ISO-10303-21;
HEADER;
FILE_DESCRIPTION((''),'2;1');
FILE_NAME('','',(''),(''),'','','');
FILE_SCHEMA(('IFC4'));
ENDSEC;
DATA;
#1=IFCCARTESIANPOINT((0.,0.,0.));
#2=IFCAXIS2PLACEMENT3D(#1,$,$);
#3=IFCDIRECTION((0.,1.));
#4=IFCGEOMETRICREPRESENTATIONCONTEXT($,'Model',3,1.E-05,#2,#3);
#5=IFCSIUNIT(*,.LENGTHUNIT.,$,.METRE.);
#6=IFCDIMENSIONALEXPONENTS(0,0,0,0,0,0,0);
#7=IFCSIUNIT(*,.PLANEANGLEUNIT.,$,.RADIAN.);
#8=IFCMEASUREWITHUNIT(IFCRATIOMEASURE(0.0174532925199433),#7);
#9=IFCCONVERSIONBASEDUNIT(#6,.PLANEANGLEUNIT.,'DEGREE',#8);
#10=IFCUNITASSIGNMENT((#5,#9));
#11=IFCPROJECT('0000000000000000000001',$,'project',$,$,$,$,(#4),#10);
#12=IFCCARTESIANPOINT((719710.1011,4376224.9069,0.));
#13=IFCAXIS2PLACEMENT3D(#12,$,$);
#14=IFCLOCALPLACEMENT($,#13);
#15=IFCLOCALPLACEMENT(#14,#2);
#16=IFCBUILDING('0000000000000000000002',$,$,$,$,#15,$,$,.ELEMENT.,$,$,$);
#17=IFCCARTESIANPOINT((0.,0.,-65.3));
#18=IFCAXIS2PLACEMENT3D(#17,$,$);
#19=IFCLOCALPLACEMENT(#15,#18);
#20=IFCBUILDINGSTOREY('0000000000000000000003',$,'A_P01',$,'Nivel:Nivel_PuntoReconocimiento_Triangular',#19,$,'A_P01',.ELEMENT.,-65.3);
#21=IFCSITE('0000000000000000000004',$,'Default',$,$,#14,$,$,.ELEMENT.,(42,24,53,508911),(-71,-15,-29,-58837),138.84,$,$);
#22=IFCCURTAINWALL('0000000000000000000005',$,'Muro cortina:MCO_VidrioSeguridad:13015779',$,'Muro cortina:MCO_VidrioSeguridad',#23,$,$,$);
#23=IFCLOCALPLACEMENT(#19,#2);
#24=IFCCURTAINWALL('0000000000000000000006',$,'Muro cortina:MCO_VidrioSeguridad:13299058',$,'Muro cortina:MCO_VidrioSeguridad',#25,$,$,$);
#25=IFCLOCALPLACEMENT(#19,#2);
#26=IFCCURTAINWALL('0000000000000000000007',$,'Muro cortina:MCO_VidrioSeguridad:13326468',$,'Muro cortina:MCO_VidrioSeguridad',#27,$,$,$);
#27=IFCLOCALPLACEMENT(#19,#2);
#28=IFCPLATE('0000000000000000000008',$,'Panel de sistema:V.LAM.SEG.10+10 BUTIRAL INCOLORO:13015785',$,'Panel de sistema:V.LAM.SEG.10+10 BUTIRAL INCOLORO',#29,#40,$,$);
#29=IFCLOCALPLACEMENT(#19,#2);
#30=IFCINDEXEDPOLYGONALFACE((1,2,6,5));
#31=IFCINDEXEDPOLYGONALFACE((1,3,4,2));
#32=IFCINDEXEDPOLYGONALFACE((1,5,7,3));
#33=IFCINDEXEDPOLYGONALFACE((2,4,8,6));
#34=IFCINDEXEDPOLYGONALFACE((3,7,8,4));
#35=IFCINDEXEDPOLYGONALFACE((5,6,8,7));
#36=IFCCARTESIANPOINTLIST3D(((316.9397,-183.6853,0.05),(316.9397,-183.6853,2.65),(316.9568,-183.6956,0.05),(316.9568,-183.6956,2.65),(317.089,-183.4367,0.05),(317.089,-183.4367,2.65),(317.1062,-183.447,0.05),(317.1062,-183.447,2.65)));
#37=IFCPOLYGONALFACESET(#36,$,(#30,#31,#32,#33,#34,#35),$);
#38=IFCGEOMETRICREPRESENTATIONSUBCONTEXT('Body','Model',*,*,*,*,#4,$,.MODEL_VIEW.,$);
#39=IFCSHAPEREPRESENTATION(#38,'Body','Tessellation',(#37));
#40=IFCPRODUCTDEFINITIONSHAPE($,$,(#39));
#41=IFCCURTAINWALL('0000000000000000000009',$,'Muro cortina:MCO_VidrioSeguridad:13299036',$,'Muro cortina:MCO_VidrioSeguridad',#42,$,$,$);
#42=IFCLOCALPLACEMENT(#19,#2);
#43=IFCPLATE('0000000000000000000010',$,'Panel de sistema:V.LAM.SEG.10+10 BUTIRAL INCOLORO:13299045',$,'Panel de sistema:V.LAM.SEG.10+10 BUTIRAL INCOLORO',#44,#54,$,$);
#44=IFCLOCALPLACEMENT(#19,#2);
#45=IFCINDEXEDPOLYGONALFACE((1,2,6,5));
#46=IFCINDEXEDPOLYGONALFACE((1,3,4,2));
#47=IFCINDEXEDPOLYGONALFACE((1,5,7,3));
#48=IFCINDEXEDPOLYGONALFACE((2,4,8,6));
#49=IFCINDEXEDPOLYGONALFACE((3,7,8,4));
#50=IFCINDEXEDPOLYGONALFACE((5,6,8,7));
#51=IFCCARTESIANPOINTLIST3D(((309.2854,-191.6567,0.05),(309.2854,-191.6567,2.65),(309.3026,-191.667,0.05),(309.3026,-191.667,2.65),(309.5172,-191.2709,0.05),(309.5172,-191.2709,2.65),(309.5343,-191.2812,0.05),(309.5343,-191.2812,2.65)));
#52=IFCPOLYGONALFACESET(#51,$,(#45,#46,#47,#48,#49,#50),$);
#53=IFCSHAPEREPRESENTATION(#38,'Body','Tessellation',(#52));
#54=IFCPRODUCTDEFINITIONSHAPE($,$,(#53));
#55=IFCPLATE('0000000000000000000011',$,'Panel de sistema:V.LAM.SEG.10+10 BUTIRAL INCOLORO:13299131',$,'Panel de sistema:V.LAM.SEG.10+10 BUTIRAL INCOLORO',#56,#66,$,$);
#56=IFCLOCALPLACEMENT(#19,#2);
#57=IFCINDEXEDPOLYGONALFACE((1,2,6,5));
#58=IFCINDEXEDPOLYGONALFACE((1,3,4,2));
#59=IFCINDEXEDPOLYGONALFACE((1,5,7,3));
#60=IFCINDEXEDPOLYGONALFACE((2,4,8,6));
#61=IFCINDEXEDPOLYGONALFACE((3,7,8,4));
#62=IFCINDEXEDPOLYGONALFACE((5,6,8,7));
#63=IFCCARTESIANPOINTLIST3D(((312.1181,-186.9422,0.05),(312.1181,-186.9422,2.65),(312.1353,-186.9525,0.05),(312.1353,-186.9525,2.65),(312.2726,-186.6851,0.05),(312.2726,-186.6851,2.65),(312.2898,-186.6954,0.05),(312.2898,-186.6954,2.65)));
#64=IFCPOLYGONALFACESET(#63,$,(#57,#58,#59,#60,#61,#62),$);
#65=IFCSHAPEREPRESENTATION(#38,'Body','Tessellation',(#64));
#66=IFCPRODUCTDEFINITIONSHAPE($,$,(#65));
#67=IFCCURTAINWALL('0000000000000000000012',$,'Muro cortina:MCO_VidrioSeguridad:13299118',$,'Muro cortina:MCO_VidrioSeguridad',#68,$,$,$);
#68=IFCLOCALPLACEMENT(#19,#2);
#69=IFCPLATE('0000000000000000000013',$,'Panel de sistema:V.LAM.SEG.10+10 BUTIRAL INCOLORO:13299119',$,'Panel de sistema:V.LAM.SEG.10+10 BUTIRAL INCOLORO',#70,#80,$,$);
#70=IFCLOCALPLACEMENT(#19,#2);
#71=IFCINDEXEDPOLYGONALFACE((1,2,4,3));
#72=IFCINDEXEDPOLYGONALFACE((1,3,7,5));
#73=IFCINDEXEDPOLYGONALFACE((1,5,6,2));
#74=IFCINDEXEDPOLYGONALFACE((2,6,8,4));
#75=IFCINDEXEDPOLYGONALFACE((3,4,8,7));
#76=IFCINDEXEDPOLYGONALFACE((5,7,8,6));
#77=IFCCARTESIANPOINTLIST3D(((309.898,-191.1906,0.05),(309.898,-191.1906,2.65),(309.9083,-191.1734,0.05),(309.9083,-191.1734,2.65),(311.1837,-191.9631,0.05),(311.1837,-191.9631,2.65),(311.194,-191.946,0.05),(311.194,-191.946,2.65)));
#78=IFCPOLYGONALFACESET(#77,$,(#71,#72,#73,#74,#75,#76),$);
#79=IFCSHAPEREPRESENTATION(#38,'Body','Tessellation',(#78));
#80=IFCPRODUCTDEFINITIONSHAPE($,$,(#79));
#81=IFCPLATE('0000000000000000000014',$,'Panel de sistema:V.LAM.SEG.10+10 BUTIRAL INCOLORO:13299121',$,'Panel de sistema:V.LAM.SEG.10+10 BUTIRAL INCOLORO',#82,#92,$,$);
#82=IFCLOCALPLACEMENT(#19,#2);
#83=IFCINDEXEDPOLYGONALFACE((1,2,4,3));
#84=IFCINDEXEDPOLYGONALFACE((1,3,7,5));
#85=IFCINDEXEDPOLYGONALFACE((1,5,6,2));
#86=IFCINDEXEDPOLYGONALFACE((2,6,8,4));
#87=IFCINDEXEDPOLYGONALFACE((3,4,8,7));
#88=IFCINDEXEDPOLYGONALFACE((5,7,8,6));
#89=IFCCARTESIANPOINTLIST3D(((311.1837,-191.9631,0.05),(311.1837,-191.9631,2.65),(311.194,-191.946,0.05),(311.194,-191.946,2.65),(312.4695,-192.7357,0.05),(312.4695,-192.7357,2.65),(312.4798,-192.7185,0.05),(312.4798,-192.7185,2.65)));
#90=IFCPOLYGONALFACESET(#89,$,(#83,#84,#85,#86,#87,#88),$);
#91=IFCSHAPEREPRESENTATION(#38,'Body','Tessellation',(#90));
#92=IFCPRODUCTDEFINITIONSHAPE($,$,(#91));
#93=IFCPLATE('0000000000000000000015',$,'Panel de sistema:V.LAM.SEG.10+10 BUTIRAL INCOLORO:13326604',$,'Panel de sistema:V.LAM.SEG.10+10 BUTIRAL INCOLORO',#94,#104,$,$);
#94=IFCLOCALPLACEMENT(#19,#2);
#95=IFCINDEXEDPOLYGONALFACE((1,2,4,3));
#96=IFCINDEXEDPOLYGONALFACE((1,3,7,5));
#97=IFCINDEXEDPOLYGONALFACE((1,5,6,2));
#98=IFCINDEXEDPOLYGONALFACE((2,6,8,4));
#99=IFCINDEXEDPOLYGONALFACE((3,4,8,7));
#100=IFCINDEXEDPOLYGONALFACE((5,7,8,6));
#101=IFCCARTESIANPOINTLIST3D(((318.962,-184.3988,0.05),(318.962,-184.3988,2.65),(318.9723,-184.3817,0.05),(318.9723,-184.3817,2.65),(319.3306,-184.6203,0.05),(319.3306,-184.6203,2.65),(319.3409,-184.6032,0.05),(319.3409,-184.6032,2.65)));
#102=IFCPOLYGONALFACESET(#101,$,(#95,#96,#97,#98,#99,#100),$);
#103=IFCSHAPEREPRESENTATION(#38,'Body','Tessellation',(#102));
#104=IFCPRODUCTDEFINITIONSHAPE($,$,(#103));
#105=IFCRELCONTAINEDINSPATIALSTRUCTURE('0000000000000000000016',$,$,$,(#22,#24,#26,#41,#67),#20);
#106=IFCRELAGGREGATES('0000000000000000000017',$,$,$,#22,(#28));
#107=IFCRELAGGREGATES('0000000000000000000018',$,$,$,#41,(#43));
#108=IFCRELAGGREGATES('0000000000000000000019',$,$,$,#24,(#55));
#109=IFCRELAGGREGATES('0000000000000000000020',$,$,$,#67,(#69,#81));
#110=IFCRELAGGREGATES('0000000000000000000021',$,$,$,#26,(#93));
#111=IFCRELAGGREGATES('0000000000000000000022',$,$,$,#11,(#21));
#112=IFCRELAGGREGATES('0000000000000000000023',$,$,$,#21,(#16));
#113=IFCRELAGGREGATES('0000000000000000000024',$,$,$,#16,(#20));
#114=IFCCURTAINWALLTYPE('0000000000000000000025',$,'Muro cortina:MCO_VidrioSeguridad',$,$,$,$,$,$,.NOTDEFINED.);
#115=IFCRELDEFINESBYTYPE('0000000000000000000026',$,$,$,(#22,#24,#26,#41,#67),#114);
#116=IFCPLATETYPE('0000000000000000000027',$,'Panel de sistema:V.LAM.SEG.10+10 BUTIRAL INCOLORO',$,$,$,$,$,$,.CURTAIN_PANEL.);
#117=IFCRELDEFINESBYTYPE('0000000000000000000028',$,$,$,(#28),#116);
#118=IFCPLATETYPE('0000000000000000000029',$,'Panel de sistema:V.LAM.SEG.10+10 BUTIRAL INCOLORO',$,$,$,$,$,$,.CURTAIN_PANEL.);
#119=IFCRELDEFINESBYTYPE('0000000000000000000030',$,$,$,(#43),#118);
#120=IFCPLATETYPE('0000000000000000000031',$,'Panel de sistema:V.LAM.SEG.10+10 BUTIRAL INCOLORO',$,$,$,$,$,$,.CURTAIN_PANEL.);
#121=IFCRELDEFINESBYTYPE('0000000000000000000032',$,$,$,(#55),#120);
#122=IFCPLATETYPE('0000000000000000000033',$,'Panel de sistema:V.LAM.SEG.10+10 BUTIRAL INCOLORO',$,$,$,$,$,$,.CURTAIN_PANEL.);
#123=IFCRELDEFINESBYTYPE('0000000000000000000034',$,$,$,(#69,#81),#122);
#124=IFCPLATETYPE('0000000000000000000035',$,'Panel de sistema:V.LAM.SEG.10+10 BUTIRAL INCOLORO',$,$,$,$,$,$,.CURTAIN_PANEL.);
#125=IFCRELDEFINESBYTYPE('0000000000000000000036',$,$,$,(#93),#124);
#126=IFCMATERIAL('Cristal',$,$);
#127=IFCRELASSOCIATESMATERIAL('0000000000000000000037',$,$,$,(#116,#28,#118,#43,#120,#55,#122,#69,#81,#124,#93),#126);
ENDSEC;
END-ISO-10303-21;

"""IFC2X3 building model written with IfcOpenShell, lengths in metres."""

from ifc_helpers import new_model, entity, si_unit, converted_unit, direction, frame, frame_2d, origin, origin_2d_with_axis, place, context, subcontext, project, spatial, rectangle, extrude, source, transform, mapped, material, type_object, type_shapes, element, aggregate, save


model = new_model("IFC2X3")

# Units and contexts
model_context = context("Model", 3, precision=1e-05, world=origin(), true_north=direction((0.0, 1.0)))
body_context = subcontext(model_context, "Body", "Model", "MODEL_VIEW")
ifc_project = project(units=[si_unit("LENGTHUNIT", "METRE"), converted_unit("PLANEANGLEUNIT", "DEGREE", entity("IfcRatioMeasure", 0.0174532925199433), si_unit("PLANEANGLEUNIT", "RADIAN"), dimensions=[0, 0, 0, 0, 0, 0, 0])], contexts=[model_context])

# Site, building, storey
site_placement = place(None, frame((719710.1011, 4376224.9069, 0.0)))
site = spatial("IfcSite", under=ifc_project, at=site_placement, Name="Default", CompositionType="ELEMENT", RefLatitude=(42, 24, 53, 508911), RefLongitude=(-71, -15, -29, -58837), RefElevation=138.84)
building_placement = place(site_placement, origin())
building = spatial("IfcBuilding", under=site, at=building_placement, CompositionType="ELEMENT")
storey_placement = place(building_placement, frame((0.0, 0.0, -65.3)))
storey = spatial("IfcBuildingStorey", under=building, at=storey_placement, Name="A_P01", ObjectType="Nivel:Nivel_PuntoReconocimiento_Triangular", LongName="A_P01", CompositionType="ELEMENT", Elevation=-65.3)

# Curtain walls
curtain_wall_type = type_object("IfcCurtainWallType", Name="Muro cortina:MCO_VidrioSeguridad", PredefinedType="NOTDEFINED")
ifc_material = material(Name="Cristal")
curtain_wall_1_placement = place(storey_placement, frame((0.0, 0.0, 65.3)))
curtain_wall_1 = element("IfcCurtainWall", 1, at=curtain_wall_1_placement, inside=storey, type_object=curtain_wall_type, Name="Muro cortina:MCO_VidrioSeguridad:13015779", ObjectType="Muro cortina:MCO_VidrioSeguridad")
curtain_wall_2_placement = place(storey_placement, frame((0.0, 0.0, 65.3)))
curtain_wall_2 = element("IfcCurtainWall", 2, at=curtain_wall_2_placement, inside=storey, type_object=curtain_wall_type, Name="Muro cortina:MCO_VidrioSeguridad:13299058", ObjectType="Muro cortina:MCO_VidrioSeguridad")
curtain_wall_3_placement = place(storey_placement, frame((0.0, 0.0, 65.3)))
curtain_wall_3 = element("IfcCurtainWall", 3, at=curtain_wall_3_placement, inside=storey, type_object=curtain_wall_type, Name="Muro cortina:MCO_VidrioSeguridad:13326468", ObjectType="Muro cortina:MCO_VidrioSeguridad")

# Plate
plate_type_1 = type_object("IfcPlateType", Name="Panel de sistema:V.LAM.SEG.10+10 BUTIRAL INCOLORO", PredefinedType="CURTAIN_PANEL", material=ifc_material)
shared_shape_1 = source(origin(), body_context, "Body", "SweptSolid", [
    extrude(rectangle(XDim=0.02, YDim=0.29, at=origin_2d_with_axis()), frame((0.0, 0.0, 0.0), z_axis=(0.0, 0.0, 1.0), x_axis=(0.0, 1.0, 0.0)), (0.0, 0.0, 1.0), 2.6),
])
type_shapes(plate_type_1, [shared_shape_1])
plate_1_placement = place(curtain_wall_1_placement, frame((317.0229, -183.5662, -65.25), z_axis=(0.0, 0.0, 1.0), x_axis=(0.515038, 0.857167, 0.0)))
plate_1 = element("IfcPlate", 4, at=plate_1_placement, type_object=plate_type_1, material=ifc_material, Name="Panel de sistema:V.LAM.SEG.10+10 BUTIRAL INCOLORO:13015785", ObjectType="Panel de sistema:V.LAM.SEG.10+10 BUTIRAL INCOLORO", context=body_context, shape_type="MappedRepresentation", body=[
    mapped(shared_shape_1, transform((0.0, 0.0, 0.0), scale=1.0)),
])
aggregate(curtain_wall_1, [plate_1])

# Curtain wall, plate
curtain_wall_4_placement = place(storey_placement, frame((0.0, 0.0, 65.3)))
curtain_wall_4 = element("IfcCurtainWall", 5, at=curtain_wall_4_placement, inside=storey, type_object=curtain_wall_type, Name="Muro cortina:MCO_VidrioSeguridad:13299036", ObjectType="Muro cortina:MCO_VidrioSeguridad")
plate_type_2 = type_object("IfcPlateType", Name="Panel de sistema:V.LAM.SEG.10+10 BUTIRAL INCOLORO", PredefinedType="CURTAIN_PANEL", material=ifc_material)
shared_shape_2 = source(origin(), body_context, "Body", "SweptSolid", [
    extrude(rectangle(XDim=0.02, YDim=0.45, at=origin_2d_with_axis()), frame((0.0, 0.0, 0.0), z_axis=(0.0, 0.0, 1.0), x_axis=(0.0, 1.0, 0.0)), (0.0, 0.0, 1.0), 2.6),
])
type_shapes(plate_type_2, [shared_shape_2])
plate_2_placement = place(curtain_wall_4_placement, frame((309.4099, -191.4689, -65.25), z_axis=(0.0, 0.0, 1.0), x_axis=(0.515038, 0.857167, 0.0)))
plate_2 = element("IfcPlate", 6, at=plate_2_placement, type_object=plate_type_2, material=ifc_material, Name="Panel de sistema:V.LAM.SEG.10+10 BUTIRAL INCOLORO:13299045", ObjectType="Panel de sistema:V.LAM.SEG.10+10 BUTIRAL INCOLORO", context=body_context, shape_type="MappedRepresentation", body=[
    mapped(shared_shape_2, transform((0.0, 0.0, 0.0), scale=1.0)),
])
aggregate(curtain_wall_4, [plate_2])

# Plate
plate_type_3 = type_object("IfcPlateType", Name="Panel de sistema:V.LAM.SEG.10+10 BUTIRAL INCOLORO", PredefinedType="CURTAIN_PANEL", material=ifc_material)
shared_shape_3 = source(origin(), body_context, "Body", "SweptSolid", [
    extrude(rectangle(XDim=0.02, YDim=0.3, at=origin_2d_with_axis()), frame((0.0, 0.0, 0.0), z_axis=(0.0, 0.0, 1.0), x_axis=(0.0, 1.0, 0.0)), (0.0, 0.0, 1.0), 2.6),
])
type_shapes(plate_type_3, [shared_shape_3])
plate_3_placement = place(curtain_wall_2_placement, frame((312.204, -186.8188, -65.25), z_axis=(0.0, 0.0, 1.0), x_axis=(0.515038, 0.857167, 0.0)))
plate_3 = element("IfcPlate", 7, at=plate_3_placement, type_object=plate_type_3, material=ifc_material, Name="Panel de sistema:V.LAM.SEG.10+10 BUTIRAL INCOLORO:13299131", ObjectType="Panel de sistema:V.LAM.SEG.10+10 BUTIRAL INCOLORO", context=body_context, shape_type="MappedRepresentation", body=[
    mapped(shared_shape_3, transform((0.0, 0.0, 0.0), scale=1.0)),
])
aggregate(curtain_wall_2, [plate_3])

# Curtain wall, plates
curtain_wall_5_placement = place(storey_placement, frame((0.0, 0.0, 65.3)))
curtain_wall_5 = element("IfcCurtainWall", 8, at=curtain_wall_5_placement, inside=storey, type_object=curtain_wall_type, Name="Muro cortina:MCO_VidrioSeguridad:13299118", ObjectType="Muro cortina:MCO_VidrioSeguridad")
plate_type_4 = type_object("IfcPlateType", Name="Panel de sistema:V.LAM.SEG.10+10 BUTIRAL INCOLORO", PredefinedType="CURTAIN_PANEL", material=ifc_material)
shared_shape_4 = source(origin(), body_context, "Body", "SweptSolid", [
    extrude(rectangle(XDim=0.02, YDim=1.5, at=frame_2d((0.0, 0.0), x_axis=(1.0, 0.0))), frame((0.0, 0.0, 0.0), z_axis=(0.0, 0.0, 1.0), x_axis=(0.0, 1.0, 0.0)), (0.0, 0.0, 1.0), 2.6),
])
type_shapes(plate_type_4, [shared_shape_4])
plate_4_placement = place(curtain_wall_5_placement, frame((310.546, -191.5683, -65.25), z_axis=(0.0, 0.0, 1.0), x_axis=(0.857167, -0.515038, 0.0)))
plate_4 = element("IfcPlate", 9, at=plate_4_placement, type_object=plate_type_4, material=ifc_material, Name="Panel de sistema:V.LAM.SEG.10+10 BUTIRAL INCOLORO:13299119", ObjectType="Panel de sistema:V.LAM.SEG.10+10 BUTIRAL INCOLORO", context=body_context, shape_type="MappedRepresentation", body=[
    mapped(shared_shape_4, transform((0.0, 0.0, 0.0), scale=1.0)),
])
plate_5_placement = place(curtain_wall_5_placement, frame((311.8317, -192.3408, -65.25), z_axis=(0.0, 0.0, 1.0), x_axis=(0.857167, -0.515038, 0.0)))
plate_5 = element("IfcPlate", 10, at=plate_5_placement, type_object=plate_type_4, material=ifc_material, Name="Panel de sistema:V.LAM.SEG.10+10 BUTIRAL INCOLORO:13299121", ObjectType="Panel de sistema:V.LAM.SEG.10+10 BUTIRAL INCOLORO", context=body_context, shape_type="MappedRepresentation", body=[
    mapped(shared_shape_4, transform((0.0, 0.0, 0.0), scale=1.0)),
])
aggregate(curtain_wall_5, [plate_4, plate_5])

# Plate
plate_type_5 = type_object("IfcPlateType", Name="Panel de sistema:V.LAM.SEG.10+10 BUTIRAL INCOLORO", PredefinedType="CURTAIN_PANEL", material=ifc_material)
shared_shape_5 = source(origin(), body_context, "Body", "SweptSolid", [
    extrude(rectangle(XDim=0.02, YDim=0.43, at=origin_2d_with_axis()), frame((0.0, 0.0, 0.0), z_axis=(0.0, 0.0, 1.0), x_axis=(0.0, 1.0, 0.0)), (0.0, 0.0, 1.0), 2.6),
])
type_shapes(plate_type_5, [shared_shape_5])
plate_6_placement = place(curtain_wall_3_placement, frame((319.1515, -184.501, -65.25), z_axis=(0.0, 0.0, 1.0), x_axis=(0.857167, -0.515038, 0.0)))
plate_6 = element("IfcPlate", 11, at=plate_6_placement, type_object=plate_type_5, material=ifc_material, Name="Panel de sistema:V.LAM.SEG.10+10 BUTIRAL INCOLORO:13326604", ObjectType="Panel de sistema:V.LAM.SEG.10+10 BUTIRAL INCOLORO", context=body_context, shape_type="MappedRepresentation", body=[
    mapped(shared_shape_5, transform((0.0, 0.0, 0.0), scale=1.0)),
])
aggregate(curtain_wall_3, [plate_6])

save(model, "model.ifc")
